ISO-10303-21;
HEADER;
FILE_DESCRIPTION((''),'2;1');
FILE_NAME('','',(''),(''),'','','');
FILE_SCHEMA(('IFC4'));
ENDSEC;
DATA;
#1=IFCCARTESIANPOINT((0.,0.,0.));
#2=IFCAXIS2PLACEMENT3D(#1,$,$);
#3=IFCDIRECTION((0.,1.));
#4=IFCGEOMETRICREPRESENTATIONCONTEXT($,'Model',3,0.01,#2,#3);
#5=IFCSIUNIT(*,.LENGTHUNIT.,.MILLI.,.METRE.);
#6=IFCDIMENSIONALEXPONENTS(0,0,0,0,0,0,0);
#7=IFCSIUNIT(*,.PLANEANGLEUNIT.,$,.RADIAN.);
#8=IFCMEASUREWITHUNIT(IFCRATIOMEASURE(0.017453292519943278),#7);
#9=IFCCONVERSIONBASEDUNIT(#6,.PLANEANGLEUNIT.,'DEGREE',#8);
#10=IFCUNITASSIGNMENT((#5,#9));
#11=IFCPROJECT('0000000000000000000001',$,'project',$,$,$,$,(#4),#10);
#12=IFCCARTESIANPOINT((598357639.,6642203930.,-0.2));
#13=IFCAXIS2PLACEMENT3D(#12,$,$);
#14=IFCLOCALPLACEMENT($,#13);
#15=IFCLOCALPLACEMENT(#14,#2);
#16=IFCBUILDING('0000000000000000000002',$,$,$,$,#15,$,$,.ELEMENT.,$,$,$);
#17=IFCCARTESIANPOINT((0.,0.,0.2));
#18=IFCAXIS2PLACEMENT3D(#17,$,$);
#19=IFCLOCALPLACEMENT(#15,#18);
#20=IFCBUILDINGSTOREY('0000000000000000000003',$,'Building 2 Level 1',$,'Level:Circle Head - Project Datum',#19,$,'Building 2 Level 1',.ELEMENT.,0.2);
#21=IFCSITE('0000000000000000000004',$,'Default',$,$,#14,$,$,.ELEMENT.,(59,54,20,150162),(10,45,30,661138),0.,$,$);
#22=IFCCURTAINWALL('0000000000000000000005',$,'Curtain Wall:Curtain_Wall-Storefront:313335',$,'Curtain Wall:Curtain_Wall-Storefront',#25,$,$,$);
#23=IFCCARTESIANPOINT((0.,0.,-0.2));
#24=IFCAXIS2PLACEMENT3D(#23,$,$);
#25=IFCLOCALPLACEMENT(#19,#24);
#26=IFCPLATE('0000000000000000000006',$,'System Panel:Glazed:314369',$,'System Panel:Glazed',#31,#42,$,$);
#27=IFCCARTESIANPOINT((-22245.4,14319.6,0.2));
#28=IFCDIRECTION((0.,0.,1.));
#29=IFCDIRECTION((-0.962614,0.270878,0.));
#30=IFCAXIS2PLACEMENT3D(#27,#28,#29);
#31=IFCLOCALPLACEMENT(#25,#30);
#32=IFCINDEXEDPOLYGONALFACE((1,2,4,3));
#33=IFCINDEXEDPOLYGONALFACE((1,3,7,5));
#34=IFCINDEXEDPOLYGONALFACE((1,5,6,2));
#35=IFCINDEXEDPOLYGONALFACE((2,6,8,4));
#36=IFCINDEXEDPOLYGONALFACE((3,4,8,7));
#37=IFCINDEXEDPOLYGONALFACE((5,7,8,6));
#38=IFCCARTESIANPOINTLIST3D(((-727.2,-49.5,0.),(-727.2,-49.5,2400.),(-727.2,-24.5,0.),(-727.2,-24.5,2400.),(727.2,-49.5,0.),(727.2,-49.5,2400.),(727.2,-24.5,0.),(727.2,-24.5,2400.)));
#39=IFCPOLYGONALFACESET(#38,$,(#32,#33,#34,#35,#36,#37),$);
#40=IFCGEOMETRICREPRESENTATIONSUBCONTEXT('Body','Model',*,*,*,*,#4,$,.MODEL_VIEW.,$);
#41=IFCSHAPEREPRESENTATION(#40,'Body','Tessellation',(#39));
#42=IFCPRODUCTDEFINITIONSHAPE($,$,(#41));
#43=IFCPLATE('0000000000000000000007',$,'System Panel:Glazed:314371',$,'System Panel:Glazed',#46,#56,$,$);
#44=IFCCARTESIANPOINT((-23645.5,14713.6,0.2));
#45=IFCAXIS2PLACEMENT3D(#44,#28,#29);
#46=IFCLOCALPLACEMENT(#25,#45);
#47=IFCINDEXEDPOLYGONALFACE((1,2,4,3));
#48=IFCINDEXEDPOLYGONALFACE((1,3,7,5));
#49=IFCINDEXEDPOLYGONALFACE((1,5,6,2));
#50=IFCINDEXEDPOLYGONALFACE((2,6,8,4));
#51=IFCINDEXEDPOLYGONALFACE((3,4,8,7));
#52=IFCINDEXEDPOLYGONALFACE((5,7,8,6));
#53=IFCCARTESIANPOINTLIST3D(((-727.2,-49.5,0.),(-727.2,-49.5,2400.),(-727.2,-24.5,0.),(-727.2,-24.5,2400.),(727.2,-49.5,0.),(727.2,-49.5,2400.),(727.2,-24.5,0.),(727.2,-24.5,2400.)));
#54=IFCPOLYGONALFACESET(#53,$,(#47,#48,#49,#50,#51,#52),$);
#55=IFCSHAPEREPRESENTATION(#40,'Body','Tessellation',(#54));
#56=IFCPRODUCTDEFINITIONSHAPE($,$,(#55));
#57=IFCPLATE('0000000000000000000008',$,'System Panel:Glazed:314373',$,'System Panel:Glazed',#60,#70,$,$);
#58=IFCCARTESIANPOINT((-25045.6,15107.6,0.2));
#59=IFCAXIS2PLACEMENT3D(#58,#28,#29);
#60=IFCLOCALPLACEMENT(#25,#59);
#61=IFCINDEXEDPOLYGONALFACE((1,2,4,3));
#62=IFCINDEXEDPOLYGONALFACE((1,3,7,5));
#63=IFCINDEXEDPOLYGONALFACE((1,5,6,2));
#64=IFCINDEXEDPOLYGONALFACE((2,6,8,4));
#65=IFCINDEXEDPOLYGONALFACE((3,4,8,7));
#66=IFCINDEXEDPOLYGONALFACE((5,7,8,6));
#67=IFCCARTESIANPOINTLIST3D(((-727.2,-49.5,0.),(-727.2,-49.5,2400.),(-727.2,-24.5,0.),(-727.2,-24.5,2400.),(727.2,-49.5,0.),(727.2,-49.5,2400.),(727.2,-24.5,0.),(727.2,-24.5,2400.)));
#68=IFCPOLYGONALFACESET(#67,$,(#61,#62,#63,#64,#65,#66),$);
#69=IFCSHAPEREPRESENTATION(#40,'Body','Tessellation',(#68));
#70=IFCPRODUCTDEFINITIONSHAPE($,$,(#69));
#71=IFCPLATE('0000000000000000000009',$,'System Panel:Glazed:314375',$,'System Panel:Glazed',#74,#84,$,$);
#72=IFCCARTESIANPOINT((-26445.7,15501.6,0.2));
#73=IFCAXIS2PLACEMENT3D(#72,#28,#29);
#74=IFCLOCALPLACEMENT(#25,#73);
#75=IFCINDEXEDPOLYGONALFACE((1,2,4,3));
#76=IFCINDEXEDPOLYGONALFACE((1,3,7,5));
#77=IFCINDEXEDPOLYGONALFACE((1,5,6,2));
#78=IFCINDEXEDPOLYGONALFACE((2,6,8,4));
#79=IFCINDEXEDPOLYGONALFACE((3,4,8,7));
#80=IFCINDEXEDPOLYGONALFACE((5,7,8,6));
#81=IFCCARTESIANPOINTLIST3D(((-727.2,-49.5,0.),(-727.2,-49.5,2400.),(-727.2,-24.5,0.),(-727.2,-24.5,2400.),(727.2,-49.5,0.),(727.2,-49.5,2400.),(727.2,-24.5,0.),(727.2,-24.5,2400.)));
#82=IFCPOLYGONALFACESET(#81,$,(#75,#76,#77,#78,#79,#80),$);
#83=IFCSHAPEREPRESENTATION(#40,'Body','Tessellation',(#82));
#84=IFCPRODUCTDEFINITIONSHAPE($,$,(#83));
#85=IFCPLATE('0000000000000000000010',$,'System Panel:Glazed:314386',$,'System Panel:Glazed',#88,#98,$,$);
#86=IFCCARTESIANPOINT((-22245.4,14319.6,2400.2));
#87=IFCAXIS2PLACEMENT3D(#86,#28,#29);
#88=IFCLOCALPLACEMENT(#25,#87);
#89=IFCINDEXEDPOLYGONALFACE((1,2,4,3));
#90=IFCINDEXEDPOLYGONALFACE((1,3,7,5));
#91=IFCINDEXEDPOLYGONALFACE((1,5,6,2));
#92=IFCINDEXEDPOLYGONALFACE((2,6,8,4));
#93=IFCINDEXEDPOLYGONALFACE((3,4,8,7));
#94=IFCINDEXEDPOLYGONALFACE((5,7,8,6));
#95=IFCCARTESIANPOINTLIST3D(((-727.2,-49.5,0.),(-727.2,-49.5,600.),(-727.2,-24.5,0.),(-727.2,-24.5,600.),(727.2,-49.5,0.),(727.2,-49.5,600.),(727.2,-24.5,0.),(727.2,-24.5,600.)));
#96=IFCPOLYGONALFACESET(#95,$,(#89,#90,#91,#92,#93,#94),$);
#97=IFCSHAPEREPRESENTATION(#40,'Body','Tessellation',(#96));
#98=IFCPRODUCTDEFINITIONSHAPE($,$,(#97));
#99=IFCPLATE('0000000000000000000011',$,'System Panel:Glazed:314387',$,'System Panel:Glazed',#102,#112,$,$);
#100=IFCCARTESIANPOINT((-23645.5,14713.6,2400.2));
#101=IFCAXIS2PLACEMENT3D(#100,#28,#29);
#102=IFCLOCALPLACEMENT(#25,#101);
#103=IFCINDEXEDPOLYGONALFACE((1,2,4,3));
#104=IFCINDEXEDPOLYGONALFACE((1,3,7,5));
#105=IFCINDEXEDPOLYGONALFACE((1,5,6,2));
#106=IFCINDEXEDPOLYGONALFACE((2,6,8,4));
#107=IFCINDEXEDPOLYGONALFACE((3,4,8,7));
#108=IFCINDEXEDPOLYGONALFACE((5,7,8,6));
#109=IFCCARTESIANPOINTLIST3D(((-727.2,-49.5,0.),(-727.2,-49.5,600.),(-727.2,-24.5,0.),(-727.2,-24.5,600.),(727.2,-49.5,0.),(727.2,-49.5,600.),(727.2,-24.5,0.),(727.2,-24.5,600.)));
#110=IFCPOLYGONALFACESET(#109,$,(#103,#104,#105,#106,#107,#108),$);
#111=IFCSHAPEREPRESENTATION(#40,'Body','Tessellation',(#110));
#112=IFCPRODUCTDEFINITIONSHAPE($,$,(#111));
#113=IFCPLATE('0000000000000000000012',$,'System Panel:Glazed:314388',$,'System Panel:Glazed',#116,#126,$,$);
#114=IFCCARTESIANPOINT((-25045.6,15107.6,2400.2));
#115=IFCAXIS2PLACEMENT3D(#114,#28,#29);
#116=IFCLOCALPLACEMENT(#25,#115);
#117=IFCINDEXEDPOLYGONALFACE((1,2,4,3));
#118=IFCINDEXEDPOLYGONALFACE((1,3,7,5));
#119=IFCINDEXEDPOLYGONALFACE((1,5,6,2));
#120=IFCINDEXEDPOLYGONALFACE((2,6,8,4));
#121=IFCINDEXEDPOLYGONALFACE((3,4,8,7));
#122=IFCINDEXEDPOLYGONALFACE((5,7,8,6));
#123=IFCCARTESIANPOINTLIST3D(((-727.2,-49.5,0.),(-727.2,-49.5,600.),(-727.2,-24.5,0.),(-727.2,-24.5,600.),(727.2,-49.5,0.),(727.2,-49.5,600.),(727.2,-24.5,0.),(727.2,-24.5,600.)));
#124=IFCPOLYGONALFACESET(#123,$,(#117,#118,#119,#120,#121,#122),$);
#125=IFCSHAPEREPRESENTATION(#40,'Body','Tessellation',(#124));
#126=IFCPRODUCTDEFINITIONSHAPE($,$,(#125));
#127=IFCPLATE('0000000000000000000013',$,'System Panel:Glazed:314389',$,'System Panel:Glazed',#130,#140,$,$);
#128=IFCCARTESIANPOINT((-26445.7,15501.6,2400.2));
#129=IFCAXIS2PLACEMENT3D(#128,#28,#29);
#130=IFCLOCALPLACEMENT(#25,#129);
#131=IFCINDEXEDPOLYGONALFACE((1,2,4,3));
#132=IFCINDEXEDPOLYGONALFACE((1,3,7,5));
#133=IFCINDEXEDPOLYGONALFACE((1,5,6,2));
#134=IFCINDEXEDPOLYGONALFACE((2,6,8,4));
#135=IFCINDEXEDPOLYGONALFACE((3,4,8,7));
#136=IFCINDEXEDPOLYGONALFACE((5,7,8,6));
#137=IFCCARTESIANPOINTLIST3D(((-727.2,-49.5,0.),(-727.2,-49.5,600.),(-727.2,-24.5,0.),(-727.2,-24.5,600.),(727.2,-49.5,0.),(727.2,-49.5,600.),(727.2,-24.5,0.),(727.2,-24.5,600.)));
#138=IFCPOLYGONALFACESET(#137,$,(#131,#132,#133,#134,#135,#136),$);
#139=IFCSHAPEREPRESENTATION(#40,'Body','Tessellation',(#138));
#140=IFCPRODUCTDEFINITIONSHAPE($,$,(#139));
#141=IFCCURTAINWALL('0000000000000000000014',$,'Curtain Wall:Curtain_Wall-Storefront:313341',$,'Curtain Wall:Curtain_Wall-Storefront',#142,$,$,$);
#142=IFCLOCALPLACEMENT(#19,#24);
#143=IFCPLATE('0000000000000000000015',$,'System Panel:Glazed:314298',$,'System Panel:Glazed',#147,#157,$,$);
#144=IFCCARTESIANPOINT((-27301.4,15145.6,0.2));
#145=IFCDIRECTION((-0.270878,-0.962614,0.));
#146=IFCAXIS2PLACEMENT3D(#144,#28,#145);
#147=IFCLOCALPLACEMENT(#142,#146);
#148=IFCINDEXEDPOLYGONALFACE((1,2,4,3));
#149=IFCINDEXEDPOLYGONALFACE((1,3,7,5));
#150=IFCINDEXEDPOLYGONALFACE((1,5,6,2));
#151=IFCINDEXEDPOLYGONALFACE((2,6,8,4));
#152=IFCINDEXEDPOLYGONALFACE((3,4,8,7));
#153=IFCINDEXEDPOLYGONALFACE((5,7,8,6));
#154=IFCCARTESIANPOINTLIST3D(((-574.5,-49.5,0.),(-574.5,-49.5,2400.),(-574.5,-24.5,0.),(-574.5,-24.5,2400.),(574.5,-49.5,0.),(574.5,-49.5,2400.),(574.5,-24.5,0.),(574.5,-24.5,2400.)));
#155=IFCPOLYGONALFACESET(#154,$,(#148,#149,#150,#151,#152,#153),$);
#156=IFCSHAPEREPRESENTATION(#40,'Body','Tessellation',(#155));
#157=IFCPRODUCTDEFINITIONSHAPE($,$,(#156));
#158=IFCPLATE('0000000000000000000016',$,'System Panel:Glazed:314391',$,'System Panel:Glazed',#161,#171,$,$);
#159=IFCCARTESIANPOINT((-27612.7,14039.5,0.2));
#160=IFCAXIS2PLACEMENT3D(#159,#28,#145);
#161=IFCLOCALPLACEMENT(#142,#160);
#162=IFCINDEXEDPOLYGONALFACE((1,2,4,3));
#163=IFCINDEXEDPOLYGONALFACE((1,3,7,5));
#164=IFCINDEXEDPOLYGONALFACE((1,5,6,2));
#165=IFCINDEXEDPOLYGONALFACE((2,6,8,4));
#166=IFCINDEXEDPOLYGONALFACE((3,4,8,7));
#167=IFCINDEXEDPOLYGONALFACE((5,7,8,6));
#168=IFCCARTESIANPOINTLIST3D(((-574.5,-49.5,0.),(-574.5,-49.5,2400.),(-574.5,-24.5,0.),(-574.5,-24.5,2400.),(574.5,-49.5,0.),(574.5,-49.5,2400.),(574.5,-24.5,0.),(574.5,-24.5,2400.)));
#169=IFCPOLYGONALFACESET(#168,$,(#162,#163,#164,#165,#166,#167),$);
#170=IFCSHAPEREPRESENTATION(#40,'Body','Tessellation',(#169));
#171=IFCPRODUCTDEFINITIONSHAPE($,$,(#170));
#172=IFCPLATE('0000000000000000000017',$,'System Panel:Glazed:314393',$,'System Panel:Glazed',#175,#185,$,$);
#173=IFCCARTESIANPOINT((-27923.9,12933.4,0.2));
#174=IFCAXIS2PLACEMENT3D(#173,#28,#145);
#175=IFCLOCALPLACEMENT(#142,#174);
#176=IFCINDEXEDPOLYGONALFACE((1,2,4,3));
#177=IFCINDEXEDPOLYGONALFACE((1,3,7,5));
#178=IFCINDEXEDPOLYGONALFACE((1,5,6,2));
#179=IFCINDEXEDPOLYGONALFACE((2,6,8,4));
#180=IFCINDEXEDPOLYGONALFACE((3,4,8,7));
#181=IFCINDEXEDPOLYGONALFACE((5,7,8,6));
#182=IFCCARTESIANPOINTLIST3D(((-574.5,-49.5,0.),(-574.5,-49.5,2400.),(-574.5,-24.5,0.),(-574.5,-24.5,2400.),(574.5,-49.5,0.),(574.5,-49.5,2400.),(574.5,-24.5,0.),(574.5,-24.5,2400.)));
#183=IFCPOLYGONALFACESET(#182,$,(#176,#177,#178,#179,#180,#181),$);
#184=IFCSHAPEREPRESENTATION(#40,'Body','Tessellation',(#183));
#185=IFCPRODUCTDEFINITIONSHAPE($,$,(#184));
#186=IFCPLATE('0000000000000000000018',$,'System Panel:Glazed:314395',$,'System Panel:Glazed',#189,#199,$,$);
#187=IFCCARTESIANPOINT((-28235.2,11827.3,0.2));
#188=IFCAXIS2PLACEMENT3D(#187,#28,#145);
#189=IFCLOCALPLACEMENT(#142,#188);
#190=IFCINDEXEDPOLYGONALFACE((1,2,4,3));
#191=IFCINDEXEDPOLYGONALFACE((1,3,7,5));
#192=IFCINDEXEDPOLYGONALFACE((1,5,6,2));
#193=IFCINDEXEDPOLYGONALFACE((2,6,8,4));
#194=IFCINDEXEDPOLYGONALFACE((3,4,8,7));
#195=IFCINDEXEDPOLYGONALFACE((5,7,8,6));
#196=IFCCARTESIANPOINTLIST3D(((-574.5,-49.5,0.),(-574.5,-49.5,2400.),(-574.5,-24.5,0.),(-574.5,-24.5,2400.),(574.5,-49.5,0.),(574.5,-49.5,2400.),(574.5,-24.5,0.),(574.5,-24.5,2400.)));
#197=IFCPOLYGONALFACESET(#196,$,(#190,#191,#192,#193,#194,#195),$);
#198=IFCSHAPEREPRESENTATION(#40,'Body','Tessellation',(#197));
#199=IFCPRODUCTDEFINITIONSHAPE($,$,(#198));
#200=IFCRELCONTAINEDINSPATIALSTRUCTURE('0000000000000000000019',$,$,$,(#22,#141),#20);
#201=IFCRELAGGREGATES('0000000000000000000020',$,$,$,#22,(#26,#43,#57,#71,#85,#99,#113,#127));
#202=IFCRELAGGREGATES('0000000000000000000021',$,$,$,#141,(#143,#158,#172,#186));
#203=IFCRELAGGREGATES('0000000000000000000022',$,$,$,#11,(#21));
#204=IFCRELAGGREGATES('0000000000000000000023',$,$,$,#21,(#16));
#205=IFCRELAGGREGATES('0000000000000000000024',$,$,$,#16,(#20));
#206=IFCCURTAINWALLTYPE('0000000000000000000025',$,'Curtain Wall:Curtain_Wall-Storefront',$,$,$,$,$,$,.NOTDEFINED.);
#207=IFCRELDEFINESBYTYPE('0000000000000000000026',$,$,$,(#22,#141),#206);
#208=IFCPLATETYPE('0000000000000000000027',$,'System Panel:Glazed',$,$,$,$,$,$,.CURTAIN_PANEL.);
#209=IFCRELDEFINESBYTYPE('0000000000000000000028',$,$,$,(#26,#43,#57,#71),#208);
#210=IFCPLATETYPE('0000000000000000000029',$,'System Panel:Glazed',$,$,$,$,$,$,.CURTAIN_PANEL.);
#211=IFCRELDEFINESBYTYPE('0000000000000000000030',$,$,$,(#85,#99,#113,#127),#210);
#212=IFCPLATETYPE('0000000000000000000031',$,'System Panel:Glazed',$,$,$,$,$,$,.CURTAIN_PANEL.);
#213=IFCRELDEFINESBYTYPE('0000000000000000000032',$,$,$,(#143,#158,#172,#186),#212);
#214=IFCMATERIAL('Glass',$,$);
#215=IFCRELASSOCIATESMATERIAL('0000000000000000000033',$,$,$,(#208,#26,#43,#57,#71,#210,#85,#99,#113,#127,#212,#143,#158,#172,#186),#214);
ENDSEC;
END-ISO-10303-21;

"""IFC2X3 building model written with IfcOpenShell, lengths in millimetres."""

from ifc_helpers import new_model, entity, si_unit, converted_unit, direction, frame, frame_2d, origin, place, context, subcontext, project, spatial, rectangle, extrude, source, transform, mapped, material, type_object, type_shapes, element, aggregate, save


model = new_model("IFC2X3")

# Units and contexts
model_context = context("Model", 3, precision=0.01, world=origin(), true_north=direction((0.0, 1.0)))
body_context = subcontext(model_context, "Body", "Model", "MODEL_VIEW")
ifc_project = project(units=[si_unit("LENGTHUNIT", "METRE", prefix="MILLI"), converted_unit("PLANEANGLEUNIT", "DEGREE", entity("IfcRatioMeasure", 0.017453292519943278), si_unit("PLANEANGLEUNIT", "RADIAN"), dimensions=[0, 0, 0, 0, 0, 0, 0])], contexts=[model_context])

# Site, building, storey
site_placement = place(None, frame((598357639.0, 6642203930.0, -0.2)))
site = spatial("IfcSite", under=ifc_project, at=site_placement, Name="Default", CompositionType="ELEMENT", RefLatitude=(59, 54, 20, 150162), RefLongitude=(10, 45, 30, 661138), RefElevation=0.0)
building_placement = place(site_placement, origin())
building = spatial("IfcBuilding", under=site, at=building_placement, CompositionType="ELEMENT")
storey_placement = place(building_placement, frame((0.0, 0.0, 0.2)))
storey = spatial("IfcBuildingStorey", under=building, at=storey_placement, Name="Building 2 Level 1", ObjectType="Level:Circle Head - Project Datum", LongName="Building 2 Level 1", CompositionType="ELEMENT", Elevation=0.2)

# Curtain walls, plates
curtain_wall_type = type_object("IfcCurtainWallType", Name="Curtain Wall:Curtain_Wall-Storefront", PredefinedType="NOTDEFINED")
curtain_wall_1_placement = place(storey_placement, frame((0.0, 0.0, -0.2)))
curtain_wall_1 = element("IfcCurtainWall", 1, at=curtain_wall_1_placement, inside=storey, type_object=curtain_wall_type, Name="Curtain Wall:Curtain_Wall-Storefront:313335", ObjectType="Curtain Wall:Curtain_Wall-Storefront")
ifc_material = material(Name="Glass")
plate_type_1 = type_object("IfcPlateType", Name="System Panel:Glazed", PredefinedType="CURTAIN_PANEL", material=ifc_material)
shared_shape_1 = source(origin(), body_context, "Body", "SweptSolid", [
    extrude(rectangle(XDim=25.0, YDim=1454.5, at=frame_2d((0.0, 0.0), x_axis=(1.0, 0.0))), frame((0.0, -37.0, 0.0), z_axis=(0.0, 0.0, 1.0), x_axis=(0.0, 1.0, 0.0)), (0.0, 0.0, 1.0), 2400.0),
])
type_shapes(plate_type_1, [shared_shape_1])
plate_1_placement = place(curtain_wall_1_placement, frame((-22245.4, 14319.6, 0.2), z_axis=(0.0, 0.0, 1.0), x_axis=(-0.962614, 0.270878, 0.0)))
plate_1 = element("IfcPlate", 2, at=plate_1_placement, type_object=plate_type_1, material=ifc_material, Name="System Panel:Glazed:314369", ObjectType="System Panel:Glazed", context=body_context, shape_type="MappedRepresentation", body=[
    mapped(shared_shape_1, transform((0.0, 0.0, 0.0), scale=1.0)),
])
plate_2_placement = place(curtain_wall_1_placement, frame((-23645.5, 14713.6, 0.2), z_axis=(0.0, 0.0, 1.0), x_axis=(-0.962614, 0.270878, 0.0)))
plate_2 = element("IfcPlate", 3, at=plate_2_placement, type_object=plate_type_1, material=ifc_material, Name="System Panel:Glazed:314371", ObjectType="System Panel:Glazed", context=body_context, shape_type="MappedRepresentation", body=[
    mapped(shared_shape_1, transform((0.0, 0.0, 0.0), scale=1.0)),
])
plate_3_placement = place(curtain_wall_1_placement, frame((-25045.6, 15107.6, 0.2), z_axis=(0.0, 0.0, 1.0), x_axis=(-0.962614, 0.270878, 0.0)))
plate_3 = element("IfcPlate", 4, at=plate_3_placement, type_object=plate_type_1, material=ifc_material, Name="System Panel:Glazed:314373", ObjectType="System Panel:Glazed", context=body_context, shape_type="MappedRepresentation", body=[
    mapped(shared_shape_1, transform((0.0, 0.0, 0.0), scale=1.0)),
])
plate_4_placement = place(curtain_wall_1_placement, frame((-26445.7, 15501.6, 0.2), z_axis=(0.0, 0.0, 1.0), x_axis=(-0.962614, 0.270878, 0.0)))
plate_4 = element("IfcPlate", 5, at=plate_4_placement, type_object=plate_type_1, material=ifc_material, Name="System Panel:Glazed:314375", ObjectType="System Panel:Glazed", context=body_context, shape_type="MappedRepresentation", body=[
    mapped(shared_shape_1, transform((0.0, 0.0, 0.0), scale=1.0)),
])
plate_type_2 = type_object("IfcPlateType", Name="System Panel:Glazed", PredefinedType="CURTAIN_PANEL", material=ifc_material)
shared_shape_2 = source(origin(), body_context, "Body", "SweptSolid", [
    extrude(rectangle(XDim=25.0, YDim=1454.5, at=frame_2d((0.0, 0.0), x_axis=(1.0, 0.0))), frame((0.0, -37.0, 0.0), z_axis=(0.0, 0.0, 1.0), x_axis=(0.0, 1.0, 0.0)), (0.0, 0.0, 1.0), 600.0),
])
type_shapes(plate_type_2, [shared_shape_2])
plate_5_placement = place(curtain_wall_1_placement, frame((-22245.4, 14319.6, 2400.2), z_axis=(0.0, 0.0, 1.0), x_axis=(-0.962614, 0.270878, 0.0)))
plate_5 = element("IfcPlate", 6, at=plate_5_placement, type_object=plate_type_2, material=ifc_material, Name="System Panel:Glazed:314386", ObjectType="System Panel:Glazed", context=body_context, shape_type="MappedRepresentation", body=[
    mapped(shared_shape_2, transform((0.0, 0.0, 0.0), scale=1.0)),
])
plate_6_placement = place(curtain_wall_1_placement, frame((-23645.5, 14713.6, 2400.2), z_axis=(0.0, 0.0, 1.0), x_axis=(-0.962614, 0.270878, 0.0)))
plate_6 = element("IfcPlate", 7, at=plate_6_placement, type_object=plate_type_2, material=ifc_material, Name="System Panel:Glazed:314387", ObjectType="System Panel:Glazed", context=body_context, shape_type="MappedRepresentation", body=[
    mapped(shared_shape_2, transform((0.0, 0.0, 0.0), scale=1.0)),
])
plate_7_placement = place(curtain_wall_1_placement, frame((-25045.6, 15107.6, 2400.2), z_axis=(0.0, 0.0, 1.0), x_axis=(-0.962614, 0.270878, 0.0)))
plate_7 = element("IfcPlate", 8, at=plate_7_placement, type_object=plate_type_2, material=ifc_material, Name="System Panel:Glazed:314388", ObjectType="System Panel:Glazed", context=body_context, shape_type="MappedRepresentation", body=[
    mapped(shared_shape_2, transform((0.0, 0.0, 0.0), scale=1.0)),
])
plate_8_placement = place(curtain_wall_1_placement, frame((-26445.7, 15501.6, 2400.2), z_axis=(0.0, 0.0, 1.0), x_axis=(-0.962614, 0.270878, 0.0)))
plate_8 = element("IfcPlate", 9, at=plate_8_placement, type_object=plate_type_2, material=ifc_material, Name="System Panel:Glazed:314389", ObjectType="System Panel:Glazed", context=body_context, shape_type="MappedRepresentation", body=[
    mapped(shared_shape_2, transform((0.0, 0.0, 0.0), scale=1.0)),
])
aggregate(curtain_wall_1, [plate_1, plate_2, plate_3, plate_4, plate_5, plate_6, plate_7, plate_8])
curtain_wall_2_placement = place(storey_placement, frame((0.0, 0.0, -0.2)))
curtain_wall_2 = element("IfcCurtainWall", 10, at=curtain_wall_2_placement, inside=storey, type_object=curtain_wall_type, Name="Curtain Wall:Curtain_Wall-Storefront:313341", ObjectType="Curtain Wall:Curtain_Wall-Storefront")
plate_type_3 = type_object("IfcPlateType", Name="System Panel:Glazed", PredefinedType="CURTAIN_PANEL", material=ifc_material)
shared_shape_3 = source(origin(), body_context, "Body", "SweptSolid", [
    extrude(rectangle(XDim=25.0, YDim=1149.1, at=frame_2d((0.0, 0.0), x_axis=(1.0, 0.0))), frame((0.0, -37.0, 0.0), z_axis=(0.0, 0.0, 1.0), x_axis=(0.0, 1.0, 0.0)), (0.0, 0.0, 1.0), 2400.0),
])
type_shapes(plate_type_3, [shared_shape_3])
plate_9_placement = place(curtain_wall_2_placement, frame((-27301.4, 15145.6, 0.2), z_axis=(0.0, 0.0, 1.0), x_axis=(-0.270878, -0.962614, 0.0)))
plate_9 = element("IfcPlate", 11, at=plate_9_placement, type_object=plate_type_3, material=ifc_material, Name="System Panel:Glazed:314298", ObjectType="System Panel:Glazed", context=body_context, shape_type="MappedRepresentation", body=[
    mapped(shared_shape_3, transform((0.0, 0.0, 0.0), scale=1.0)),
])
plate_10_placement = place(curtain_wall_2_placement, frame((-27612.7, 14039.5, 0.2), z_axis=(0.0, 0.0, 1.0), x_axis=(-0.270878, -0.962614, 0.0)))
plate_10 = element("IfcPlate", 12, at=plate_10_placement, type_object=plate_type_3, material=ifc_material, Name="System Panel:Glazed:314391", ObjectType="System Panel:Glazed", context=body_context, shape_type="MappedRepresentation", body=[
    mapped(shared_shape_3, transform((0.0, 0.0, 0.0), scale=1.0)),
])
plate_11_placement = place(curtain_wall_2_placement, frame((-27923.9, 12933.4, 0.2), z_axis=(0.0, 0.0, 1.0), x_axis=(-0.270878, -0.962614, 0.0)))
plate_11 = element("IfcPlate", 13, at=plate_11_placement, type_object=plate_type_3, material=ifc_material, Name="System Panel:Glazed:314393", ObjectType="System Panel:Glazed", context=body_context, shape_type="MappedRepresentation", body=[
    mapped(shared_shape_3, transform((0.0, 0.0, 0.0), scale=1.0)),
])
plate_12_placement = place(curtain_wall_2_placement, frame((-28235.2, 11827.3, 0.2), z_axis=(0.0, 0.0, 1.0), x_axis=(-0.270878, -0.962614, 0.0)))
plate_12 = element("IfcPlate", 14, at=plate_12_placement, type_object=plate_type_3, material=ifc_material, Name="System Panel:Glazed:314395", ObjectType="System Panel:Glazed", context=body_context, shape_type="MappedRepresentation", body=[
    mapped(shared_shape_3, transform((0.0, 0.0, 0.0), scale=1.0)),
])
aggregate(curtain_wall_2, [plate_9, plate_10, plate_11, plate_12])

save(model, "model.ifc")
